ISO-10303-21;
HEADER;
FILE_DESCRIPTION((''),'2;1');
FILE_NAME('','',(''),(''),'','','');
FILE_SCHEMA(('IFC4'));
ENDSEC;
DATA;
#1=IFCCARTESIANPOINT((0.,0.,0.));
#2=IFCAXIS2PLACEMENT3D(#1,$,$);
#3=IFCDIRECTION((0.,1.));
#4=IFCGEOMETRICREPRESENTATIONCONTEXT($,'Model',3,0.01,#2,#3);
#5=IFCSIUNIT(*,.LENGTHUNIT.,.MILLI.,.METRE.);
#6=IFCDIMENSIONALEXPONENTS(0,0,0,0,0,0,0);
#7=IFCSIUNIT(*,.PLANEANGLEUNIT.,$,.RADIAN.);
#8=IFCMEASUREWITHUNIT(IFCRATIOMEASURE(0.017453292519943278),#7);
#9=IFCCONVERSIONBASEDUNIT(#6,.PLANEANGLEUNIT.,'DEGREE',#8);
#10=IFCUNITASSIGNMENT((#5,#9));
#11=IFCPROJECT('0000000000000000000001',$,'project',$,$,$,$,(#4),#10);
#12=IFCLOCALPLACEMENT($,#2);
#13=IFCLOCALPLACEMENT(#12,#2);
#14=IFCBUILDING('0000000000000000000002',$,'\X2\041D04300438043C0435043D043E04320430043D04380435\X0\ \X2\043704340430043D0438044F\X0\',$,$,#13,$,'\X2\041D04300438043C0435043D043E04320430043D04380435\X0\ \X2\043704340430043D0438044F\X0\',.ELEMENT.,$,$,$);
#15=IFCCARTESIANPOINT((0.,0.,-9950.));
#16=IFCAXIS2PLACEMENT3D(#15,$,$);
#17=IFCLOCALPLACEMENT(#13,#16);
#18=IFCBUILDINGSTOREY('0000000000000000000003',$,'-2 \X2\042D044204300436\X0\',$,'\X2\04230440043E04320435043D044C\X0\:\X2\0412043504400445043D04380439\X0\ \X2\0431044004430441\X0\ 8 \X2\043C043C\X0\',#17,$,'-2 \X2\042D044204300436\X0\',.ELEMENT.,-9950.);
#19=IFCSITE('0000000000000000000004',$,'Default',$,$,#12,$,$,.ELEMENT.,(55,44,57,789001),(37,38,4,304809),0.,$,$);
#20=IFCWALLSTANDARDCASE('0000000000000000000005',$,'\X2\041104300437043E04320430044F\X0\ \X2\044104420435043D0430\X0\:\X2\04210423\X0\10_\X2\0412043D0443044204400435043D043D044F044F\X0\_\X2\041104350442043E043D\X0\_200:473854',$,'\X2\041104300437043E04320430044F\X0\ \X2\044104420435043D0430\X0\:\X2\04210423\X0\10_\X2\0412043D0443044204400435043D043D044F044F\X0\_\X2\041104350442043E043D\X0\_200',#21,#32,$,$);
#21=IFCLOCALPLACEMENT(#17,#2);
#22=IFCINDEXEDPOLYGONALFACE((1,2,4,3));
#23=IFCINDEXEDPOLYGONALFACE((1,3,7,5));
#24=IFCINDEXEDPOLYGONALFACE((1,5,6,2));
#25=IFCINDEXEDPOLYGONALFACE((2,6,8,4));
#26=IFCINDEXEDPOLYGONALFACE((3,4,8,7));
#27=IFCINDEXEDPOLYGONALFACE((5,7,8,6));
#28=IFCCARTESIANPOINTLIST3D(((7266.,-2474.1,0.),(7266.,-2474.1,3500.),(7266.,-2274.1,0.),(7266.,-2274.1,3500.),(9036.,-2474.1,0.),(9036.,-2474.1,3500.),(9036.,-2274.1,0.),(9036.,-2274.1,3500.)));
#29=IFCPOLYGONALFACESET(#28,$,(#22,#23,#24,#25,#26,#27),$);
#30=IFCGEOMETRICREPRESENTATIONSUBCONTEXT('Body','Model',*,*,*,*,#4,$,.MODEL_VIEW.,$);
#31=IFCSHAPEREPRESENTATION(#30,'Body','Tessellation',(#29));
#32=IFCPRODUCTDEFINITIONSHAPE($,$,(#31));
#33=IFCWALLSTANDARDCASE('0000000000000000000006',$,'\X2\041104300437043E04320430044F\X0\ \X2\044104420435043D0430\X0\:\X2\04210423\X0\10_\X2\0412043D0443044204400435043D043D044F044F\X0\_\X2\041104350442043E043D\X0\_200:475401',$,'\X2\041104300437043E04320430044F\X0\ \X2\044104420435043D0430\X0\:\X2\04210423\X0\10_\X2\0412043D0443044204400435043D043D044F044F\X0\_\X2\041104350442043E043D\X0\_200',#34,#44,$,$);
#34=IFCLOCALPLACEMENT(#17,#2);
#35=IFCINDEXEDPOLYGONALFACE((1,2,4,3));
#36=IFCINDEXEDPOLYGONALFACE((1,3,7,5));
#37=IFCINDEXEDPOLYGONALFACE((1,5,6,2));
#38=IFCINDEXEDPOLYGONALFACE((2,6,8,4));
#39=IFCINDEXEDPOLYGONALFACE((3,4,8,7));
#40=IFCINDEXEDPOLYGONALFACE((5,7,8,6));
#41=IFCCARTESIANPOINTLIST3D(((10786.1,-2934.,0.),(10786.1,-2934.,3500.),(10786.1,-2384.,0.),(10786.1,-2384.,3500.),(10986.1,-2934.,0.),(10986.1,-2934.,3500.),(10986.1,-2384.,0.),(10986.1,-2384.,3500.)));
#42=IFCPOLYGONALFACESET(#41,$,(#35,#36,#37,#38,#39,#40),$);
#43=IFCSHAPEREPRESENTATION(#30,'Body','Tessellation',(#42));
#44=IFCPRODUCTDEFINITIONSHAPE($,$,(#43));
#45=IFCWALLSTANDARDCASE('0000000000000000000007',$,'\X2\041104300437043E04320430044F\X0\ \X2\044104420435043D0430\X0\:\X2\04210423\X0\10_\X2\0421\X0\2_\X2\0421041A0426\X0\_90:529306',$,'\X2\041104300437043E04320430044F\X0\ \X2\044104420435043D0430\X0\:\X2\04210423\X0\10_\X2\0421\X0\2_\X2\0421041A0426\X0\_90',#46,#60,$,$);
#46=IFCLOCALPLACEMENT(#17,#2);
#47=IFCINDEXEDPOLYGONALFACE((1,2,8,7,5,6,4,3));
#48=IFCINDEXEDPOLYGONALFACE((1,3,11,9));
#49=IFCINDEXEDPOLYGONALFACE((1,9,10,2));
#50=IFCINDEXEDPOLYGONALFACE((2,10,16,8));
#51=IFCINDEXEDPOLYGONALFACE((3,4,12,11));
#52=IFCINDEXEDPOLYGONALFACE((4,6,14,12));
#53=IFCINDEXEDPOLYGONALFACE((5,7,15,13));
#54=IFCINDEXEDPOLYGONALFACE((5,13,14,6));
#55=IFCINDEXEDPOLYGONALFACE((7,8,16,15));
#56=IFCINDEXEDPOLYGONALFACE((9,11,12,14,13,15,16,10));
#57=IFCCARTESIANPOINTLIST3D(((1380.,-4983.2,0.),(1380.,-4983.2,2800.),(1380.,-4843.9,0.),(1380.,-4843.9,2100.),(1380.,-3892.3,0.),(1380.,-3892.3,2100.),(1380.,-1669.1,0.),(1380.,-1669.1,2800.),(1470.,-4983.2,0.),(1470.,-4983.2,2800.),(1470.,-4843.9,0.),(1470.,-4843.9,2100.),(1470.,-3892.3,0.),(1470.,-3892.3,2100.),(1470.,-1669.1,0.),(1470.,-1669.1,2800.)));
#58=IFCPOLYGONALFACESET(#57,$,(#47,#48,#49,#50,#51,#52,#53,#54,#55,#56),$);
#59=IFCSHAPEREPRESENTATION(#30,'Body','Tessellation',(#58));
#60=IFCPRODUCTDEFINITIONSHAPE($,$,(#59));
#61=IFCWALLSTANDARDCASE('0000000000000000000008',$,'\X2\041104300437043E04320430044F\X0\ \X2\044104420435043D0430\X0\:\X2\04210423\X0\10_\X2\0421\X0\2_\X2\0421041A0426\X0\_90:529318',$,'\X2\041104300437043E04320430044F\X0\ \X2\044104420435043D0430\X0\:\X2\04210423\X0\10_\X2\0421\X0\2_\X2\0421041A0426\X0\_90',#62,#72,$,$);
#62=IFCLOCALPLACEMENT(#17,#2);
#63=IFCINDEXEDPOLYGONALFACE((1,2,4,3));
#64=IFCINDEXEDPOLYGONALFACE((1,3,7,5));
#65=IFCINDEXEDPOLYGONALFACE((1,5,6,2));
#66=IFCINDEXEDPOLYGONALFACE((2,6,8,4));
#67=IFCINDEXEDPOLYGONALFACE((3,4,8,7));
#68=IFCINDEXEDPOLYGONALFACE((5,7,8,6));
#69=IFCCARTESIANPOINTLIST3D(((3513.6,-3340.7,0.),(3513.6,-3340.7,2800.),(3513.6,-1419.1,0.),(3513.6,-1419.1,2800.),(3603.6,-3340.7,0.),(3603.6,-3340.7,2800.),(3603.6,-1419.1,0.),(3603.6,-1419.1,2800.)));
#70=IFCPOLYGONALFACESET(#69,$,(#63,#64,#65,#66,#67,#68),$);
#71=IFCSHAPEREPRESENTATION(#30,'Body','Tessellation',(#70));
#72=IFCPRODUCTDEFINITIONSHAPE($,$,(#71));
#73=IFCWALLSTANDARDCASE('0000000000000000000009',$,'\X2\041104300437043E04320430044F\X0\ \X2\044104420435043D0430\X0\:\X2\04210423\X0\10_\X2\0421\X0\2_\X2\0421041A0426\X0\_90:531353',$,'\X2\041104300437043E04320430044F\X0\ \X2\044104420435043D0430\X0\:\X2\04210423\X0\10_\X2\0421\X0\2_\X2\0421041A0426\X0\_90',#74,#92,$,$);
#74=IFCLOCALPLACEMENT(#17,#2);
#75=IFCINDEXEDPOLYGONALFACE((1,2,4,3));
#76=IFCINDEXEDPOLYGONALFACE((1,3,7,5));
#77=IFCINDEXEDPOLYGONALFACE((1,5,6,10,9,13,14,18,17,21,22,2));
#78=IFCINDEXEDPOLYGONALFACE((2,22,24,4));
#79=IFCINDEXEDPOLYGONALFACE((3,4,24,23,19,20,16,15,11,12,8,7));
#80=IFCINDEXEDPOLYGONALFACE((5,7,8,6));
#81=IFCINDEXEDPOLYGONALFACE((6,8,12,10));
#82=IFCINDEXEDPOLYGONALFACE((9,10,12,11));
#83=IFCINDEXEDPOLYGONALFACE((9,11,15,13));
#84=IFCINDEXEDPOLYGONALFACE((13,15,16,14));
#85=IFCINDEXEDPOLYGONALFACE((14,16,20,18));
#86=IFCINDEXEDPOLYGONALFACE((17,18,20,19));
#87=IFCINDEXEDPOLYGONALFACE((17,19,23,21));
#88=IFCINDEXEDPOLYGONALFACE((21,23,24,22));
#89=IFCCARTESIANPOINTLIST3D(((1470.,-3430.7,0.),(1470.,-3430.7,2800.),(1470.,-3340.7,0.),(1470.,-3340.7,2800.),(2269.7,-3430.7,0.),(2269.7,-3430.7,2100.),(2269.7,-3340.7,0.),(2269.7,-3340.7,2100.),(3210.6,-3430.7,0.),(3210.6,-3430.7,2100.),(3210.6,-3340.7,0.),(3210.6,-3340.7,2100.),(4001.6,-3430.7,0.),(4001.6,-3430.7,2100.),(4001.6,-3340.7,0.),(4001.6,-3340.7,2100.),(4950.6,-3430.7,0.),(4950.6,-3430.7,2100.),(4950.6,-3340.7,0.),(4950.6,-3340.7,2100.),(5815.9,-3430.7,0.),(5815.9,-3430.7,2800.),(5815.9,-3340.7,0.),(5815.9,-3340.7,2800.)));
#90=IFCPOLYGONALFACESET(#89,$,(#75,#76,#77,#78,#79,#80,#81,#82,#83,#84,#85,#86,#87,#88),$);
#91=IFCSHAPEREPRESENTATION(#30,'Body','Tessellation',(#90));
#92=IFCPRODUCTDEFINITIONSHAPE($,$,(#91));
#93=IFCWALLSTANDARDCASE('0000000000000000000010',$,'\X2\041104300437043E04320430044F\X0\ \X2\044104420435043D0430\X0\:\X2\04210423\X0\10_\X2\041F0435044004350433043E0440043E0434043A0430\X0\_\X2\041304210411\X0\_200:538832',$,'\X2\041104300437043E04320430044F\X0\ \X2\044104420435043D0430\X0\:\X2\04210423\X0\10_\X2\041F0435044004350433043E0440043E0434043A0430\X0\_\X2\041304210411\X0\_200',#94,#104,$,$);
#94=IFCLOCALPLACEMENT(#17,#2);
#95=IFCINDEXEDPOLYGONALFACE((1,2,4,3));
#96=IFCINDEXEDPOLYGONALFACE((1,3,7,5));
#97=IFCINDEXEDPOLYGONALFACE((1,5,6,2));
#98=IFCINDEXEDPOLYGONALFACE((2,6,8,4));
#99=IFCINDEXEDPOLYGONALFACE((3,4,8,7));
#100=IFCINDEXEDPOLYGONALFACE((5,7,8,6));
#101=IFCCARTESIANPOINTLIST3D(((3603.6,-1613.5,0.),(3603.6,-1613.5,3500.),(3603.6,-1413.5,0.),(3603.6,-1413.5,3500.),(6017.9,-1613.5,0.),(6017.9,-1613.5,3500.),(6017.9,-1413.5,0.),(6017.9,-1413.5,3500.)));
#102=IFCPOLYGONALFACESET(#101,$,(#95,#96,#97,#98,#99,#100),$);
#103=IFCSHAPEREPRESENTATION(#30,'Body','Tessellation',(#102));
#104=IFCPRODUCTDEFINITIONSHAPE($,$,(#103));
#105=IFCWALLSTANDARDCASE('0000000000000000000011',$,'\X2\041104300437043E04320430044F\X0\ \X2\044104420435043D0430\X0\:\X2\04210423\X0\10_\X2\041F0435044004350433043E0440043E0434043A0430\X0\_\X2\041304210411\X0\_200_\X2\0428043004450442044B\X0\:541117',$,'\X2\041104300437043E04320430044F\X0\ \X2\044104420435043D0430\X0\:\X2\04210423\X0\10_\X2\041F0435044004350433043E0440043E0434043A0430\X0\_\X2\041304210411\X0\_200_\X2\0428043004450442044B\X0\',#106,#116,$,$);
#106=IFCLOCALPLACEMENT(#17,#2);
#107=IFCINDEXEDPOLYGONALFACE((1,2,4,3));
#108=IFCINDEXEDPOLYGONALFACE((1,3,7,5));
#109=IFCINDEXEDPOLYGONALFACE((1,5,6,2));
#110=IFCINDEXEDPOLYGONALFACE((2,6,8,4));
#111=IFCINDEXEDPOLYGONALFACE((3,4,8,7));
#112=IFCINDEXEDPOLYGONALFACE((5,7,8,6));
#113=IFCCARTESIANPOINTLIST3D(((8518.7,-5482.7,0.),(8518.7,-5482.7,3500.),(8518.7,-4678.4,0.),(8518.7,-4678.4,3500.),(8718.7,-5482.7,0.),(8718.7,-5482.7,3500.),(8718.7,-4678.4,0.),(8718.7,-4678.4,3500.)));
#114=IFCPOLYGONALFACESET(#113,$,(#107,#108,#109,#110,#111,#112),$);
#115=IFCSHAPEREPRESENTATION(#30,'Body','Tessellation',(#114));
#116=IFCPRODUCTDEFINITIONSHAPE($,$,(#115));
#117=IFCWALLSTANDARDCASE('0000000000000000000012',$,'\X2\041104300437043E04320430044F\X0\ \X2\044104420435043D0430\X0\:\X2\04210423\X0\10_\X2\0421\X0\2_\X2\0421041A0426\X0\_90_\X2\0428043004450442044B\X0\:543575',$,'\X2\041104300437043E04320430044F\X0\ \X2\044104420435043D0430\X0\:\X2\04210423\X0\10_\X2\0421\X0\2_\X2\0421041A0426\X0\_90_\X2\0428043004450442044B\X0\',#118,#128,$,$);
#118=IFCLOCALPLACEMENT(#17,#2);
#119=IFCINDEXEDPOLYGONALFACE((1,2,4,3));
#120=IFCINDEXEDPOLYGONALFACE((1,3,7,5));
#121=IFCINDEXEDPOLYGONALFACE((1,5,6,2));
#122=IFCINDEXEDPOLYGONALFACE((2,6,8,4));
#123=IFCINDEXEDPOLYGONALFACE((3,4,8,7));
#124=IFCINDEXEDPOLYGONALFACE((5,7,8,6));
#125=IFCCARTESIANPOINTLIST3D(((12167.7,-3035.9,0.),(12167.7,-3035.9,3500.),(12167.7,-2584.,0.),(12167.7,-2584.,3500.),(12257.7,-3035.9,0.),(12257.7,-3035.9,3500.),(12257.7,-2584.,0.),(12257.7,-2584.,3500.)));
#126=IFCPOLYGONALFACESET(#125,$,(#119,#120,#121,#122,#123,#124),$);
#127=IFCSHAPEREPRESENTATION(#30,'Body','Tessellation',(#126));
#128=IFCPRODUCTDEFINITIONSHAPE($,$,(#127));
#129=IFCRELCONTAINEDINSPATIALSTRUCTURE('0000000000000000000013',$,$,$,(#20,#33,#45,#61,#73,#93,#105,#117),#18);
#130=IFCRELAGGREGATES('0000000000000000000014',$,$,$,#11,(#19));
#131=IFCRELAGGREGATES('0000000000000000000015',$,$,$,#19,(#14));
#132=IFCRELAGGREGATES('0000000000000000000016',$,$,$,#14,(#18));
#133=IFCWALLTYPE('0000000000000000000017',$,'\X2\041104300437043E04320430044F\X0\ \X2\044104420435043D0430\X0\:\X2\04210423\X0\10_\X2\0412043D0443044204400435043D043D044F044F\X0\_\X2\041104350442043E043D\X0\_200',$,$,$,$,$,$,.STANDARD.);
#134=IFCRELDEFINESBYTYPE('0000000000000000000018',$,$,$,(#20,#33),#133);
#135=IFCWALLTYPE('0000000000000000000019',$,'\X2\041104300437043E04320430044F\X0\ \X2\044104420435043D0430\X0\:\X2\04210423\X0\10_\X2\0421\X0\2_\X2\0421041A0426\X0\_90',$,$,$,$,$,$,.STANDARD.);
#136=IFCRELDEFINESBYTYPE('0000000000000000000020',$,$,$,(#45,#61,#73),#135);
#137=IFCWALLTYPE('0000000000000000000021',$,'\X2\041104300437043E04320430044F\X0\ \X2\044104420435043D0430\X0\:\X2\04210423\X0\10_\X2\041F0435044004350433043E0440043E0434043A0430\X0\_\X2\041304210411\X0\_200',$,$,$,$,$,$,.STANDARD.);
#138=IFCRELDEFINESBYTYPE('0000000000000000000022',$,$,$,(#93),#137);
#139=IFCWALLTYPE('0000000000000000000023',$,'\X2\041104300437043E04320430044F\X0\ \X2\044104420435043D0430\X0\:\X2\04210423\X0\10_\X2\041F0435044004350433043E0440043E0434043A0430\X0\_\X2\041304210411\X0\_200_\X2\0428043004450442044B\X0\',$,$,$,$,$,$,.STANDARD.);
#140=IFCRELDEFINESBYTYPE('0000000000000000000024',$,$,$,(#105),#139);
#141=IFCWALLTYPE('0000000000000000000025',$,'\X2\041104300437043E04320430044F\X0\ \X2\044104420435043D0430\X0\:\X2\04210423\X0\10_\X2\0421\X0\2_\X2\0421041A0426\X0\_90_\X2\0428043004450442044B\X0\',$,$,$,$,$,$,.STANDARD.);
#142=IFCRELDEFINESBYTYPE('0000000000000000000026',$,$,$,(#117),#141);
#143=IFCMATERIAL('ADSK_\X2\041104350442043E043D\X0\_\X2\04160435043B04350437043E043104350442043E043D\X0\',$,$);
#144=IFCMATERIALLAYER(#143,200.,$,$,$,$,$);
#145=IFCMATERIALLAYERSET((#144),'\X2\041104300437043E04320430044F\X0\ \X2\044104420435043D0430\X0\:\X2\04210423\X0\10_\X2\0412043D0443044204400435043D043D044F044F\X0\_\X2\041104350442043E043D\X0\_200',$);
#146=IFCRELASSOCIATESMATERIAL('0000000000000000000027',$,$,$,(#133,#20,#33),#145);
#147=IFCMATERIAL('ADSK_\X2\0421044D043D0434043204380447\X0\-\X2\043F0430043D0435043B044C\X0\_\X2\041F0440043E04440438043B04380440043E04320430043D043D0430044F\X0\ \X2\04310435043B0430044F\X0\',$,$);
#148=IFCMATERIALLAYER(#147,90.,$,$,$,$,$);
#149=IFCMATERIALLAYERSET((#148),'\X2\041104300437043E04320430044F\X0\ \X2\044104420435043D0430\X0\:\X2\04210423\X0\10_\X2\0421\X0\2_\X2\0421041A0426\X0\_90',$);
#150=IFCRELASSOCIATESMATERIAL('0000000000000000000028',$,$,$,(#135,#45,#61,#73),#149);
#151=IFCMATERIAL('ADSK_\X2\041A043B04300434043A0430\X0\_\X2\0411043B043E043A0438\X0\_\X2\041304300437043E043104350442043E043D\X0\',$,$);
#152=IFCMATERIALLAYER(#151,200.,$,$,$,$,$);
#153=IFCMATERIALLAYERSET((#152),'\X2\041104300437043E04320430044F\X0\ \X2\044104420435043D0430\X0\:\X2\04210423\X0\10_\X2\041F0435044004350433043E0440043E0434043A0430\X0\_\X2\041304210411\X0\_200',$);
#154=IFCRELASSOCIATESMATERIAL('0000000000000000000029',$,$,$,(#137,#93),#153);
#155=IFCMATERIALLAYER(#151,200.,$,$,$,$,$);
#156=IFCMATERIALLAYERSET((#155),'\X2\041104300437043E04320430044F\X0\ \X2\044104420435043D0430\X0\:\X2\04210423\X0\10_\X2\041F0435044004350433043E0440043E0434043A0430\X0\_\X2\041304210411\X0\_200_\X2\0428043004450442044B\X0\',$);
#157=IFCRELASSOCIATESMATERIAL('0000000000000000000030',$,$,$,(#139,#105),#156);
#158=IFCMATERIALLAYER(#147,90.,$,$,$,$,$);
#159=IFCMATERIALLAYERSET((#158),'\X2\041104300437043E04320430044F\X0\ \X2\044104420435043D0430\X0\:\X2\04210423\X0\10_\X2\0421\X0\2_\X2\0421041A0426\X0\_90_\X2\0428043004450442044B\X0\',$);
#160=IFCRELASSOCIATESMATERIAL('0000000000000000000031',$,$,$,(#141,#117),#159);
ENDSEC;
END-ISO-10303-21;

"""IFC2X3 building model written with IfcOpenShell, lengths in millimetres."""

from ifc_helpers import new_model, entity, si_unit, converted_unit, direction, frame, frame_2d, origin, place, context, subcontext, project, spatial, rectangle, extrude, material, layer, layer_set, layer_usage, type_object, element, save


model = new_model("IFC2X3")

# Units and contexts
model_context = context("Model", 3, precision=0.01, world=origin(), true_north=direction((0.0, 1.0)))
body_context = subcontext(model_context, "Body", "Model", "MODEL_VIEW")
ifc_project = project(units=[si_unit("LENGTHUNIT", "METRE", prefix="MILLI"), converted_unit("PLANEANGLEUNIT", "DEGREE", entity("IfcRatioMeasure", 0.017453292519943278), si_unit("PLANEANGLEUNIT", "RADIAN"), dimensions=[0, 0, 0, 0, 0, 0, 0])], contexts=[model_context])

# Site, building, storey
site_placement = place(None, origin())
site = spatial("IfcSite", under=ifc_project, at=site_placement, Name="Default", CompositionType="ELEMENT", RefLatitude=(55, 44, 57, 789001), RefLongitude=(37, 38, 4, 304809), RefElevation=0.0)
building_placement = place(site_placement, origin())
building = spatial("IfcBuilding", under=site, at=building_placement, Name="Наименование здания", LongName="Наименование здания", CompositionType="ELEMENT")
storey_placement = place(building_placement, frame((0.0, 0.0, -9950.0)))
storey = spatial("IfcBuildingStorey", under=building, at=storey_placement, Name="-2 Этаж", ObjectType="Уровень:Верхний брус 8 мм", LongName="-2 Этаж", CompositionType="ELEMENT", Elevation=-9950.0)

# Shared definitions
ifc_material_1 = material(Name="ADSK_Бетон_Железобетон")

# Walls
ifc_layer_1 = layer(ifc_material_1, 200.0)
ifc_layer_set_1 = layer_set([ifc_layer_1], Name="Базовая стена:СУ10_Внутренняя_Бетон_200")
ifc_layer_usage_1 = layer_usage(ifc_layer_set_1, "AXIS2", "NEGATIVE", 100.0)
wall_type_1 = type_object("IfcWallType", Name="Базовая стена:СУ10_Внутренняя_Бетон_200", PredefinedType="STANDARD", material=ifc_layer_set_1)
wall_1_placement = place(storey_placement, frame((9036.0, -2374.1, 0.0), z_axis=(0.0, 0.0, 1.0), x_axis=(-1.0, 0.0, 0.0)))
element("IfcWallStandardCase", 1, at=wall_1_placement, inside=storey, type_object=wall_type_1, material=ifc_layer_usage_1, Name="Базовая стена:СУ10_Внутренняя_Бетон_200:473854", ObjectType="Базовая стена:СУ10_Внутренняя_Бетон_200", context=body_context, shape_type="SweptSolid", body=[
    extrude(rectangle(XDim=1770.0, YDim=200.0, at=frame_2d((885.0, 0.0), x_axis=(-1.0, 0.0))), origin(), (0.0, 0.0, 1.0), 3500.0),
])
wall_2_placement = place(storey_placement, frame((10886.1, -2384.0, 0.0), z_axis=(0.0, 0.0, 1.0), x_axis=(0.0, -1.0, 0.0)))
element("IfcWallStandardCase", 2, at=wall_2_placement, inside=storey, type_object=wall_type_1, material=ifc_layer_usage_1, Name="Базовая стена:СУ10_Внутренняя_Бетон_200:475401", ObjectType="Базовая стена:СУ10_Внутренняя_Бетон_200", context=body_context, shape_type="SweptSolid", body=[
    extrude(rectangle(XDim=550.0, YDim=200.0, at=frame_2d((275.0, 0.0), x_axis=(-1.0, 0.0))), origin(), (0.0, 0.0, 1.0), 3500.0),
])

# Wall, opening
ifc_material_2 = material(Name="ADSK_Сэндвич-панель_Профилированная белая")
ifc_layer_2 = layer(ifc_material_2, 90.0)
ifc_layer_set_2 = layer_set([ifc_layer_2], Name="Базовая стена:СУ10_С2_СКЦ_90")
ifc_layer_usage_2 = layer_usage(ifc_layer_set_2, "AXIS2", "NEGATIVE", 45.0)
wall_type_2 = type_object("IfcWallType", Name="Базовая стена:СУ10_С2_СКЦ_90", PredefinedType="STANDARD", material=ifc_layer_set_2)
wall_3_placement = place(storey_placement, frame((1425.0, -1669.1, 0.0), z_axis=(0.0, 0.0, 1.0), x_axis=(0.0, -1.0, 0.0)))
wall_3 = element("IfcWallStandardCase", 3, at=wall_3_placement, inside=storey, type_object=wall_type_2, material=ifc_layer_usage_2, Name="Базовая стена:СУ10_С2_СКЦ_90:529306", ObjectType="Базовая стена:СУ10_С2_СКЦ_90", context=body_context, shape_type="SweptSolid", body=[
    extrude(rectangle(XDim=3314.1, YDim=90.0, at=frame_2d((1657.1, 0.0), x_axis=(-1.0, 0.0))), origin(), (0.0, 0.0, 1.0), 2800.0),
])
opening_1_placement = place(wall_3_placement, origin())
element("IfcOpeningElement", 4, at=opening_1_placement, cuts=wall_3, ObjectType="Opening", context=body_context, shape_type="SweptSolid", body=[
    extrude(rectangle(XDim=2100.0, YDim=951.5, at=frame_2d((0.0, 0.0), x_axis=(1.0, 0.0))), frame((2699.0, -45.0, 1050.0), z_axis=(0.0, 1.0, 0.0), x_axis=(0.0, 0.0, -1.0)), (0.0, 0.0, 1.0), 90.0),
])

# Wall
wall_4_placement = place(storey_placement, frame((3558.6, -1419.1, 0.0), z_axis=(0.0, 0.0, 1.0), x_axis=(0.0, -1.0, 0.0)))
element("IfcWallStandardCase", 5, at=wall_4_placement, inside=storey, type_object=wall_type_2, material=ifc_layer_usage_2, Name="Базовая стена:СУ10_С2_СКЦ_90:529318", ObjectType="Базовая стена:СУ10_С2_СКЦ_90", context=body_context, shape_type="SweptSolid", body=[
    extrude(rectangle(XDim=1921.6, YDim=90.0, at=frame_2d((960.8, 0.0), x_axis=(-1.0, 0.0))), origin(), (0.0, 0.0, 1.0), 2800.0),
])

# Wall, openings
wall_5_placement = place(storey_placement, frame((5815.9, -3385.7, 0.0), z_axis=(0.0, 0.0, 1.0), x_axis=(-1.0, 0.0, 0.0)))
wall_5 = element("IfcWallStandardCase", 6, at=wall_5_placement, inside=storey, type_object=wall_type_2, material=ifc_layer_usage_2, Name="Базовая стена:СУ10_С2_СКЦ_90:531353", ObjectType="Базовая стена:СУ10_С2_СКЦ_90", context=body_context, shape_type="SweptSolid", body=[
    extrude(rectangle(XDim=4345.8, YDim=90.0, at=frame_2d((2172.9, 0.0), x_axis=(1.0, 0.0))), origin(), (0.0, 0.0, 1.0), 2800.0),
])
opening_2_placement = place(wall_5_placement, origin())
element("IfcOpeningElement", 7, at=opening_2_placement, cuts=wall_5, ObjectType="Opening", context=body_context, shape_type="SweptSolid", body=[
    extrude(rectangle(XDim=2100.0, YDim=941.0, at=frame_2d((0.0, 0.0), x_axis=(1.0, 0.0))), frame((3075.7, -45.0, 1050.0), z_axis=(0.0, 1.0, 0.0), x_axis=(0.0, 0.0, -1.0)), (0.0, 0.0, 1.0), 90.0),
])
opening_3_placement = place(wall_5_placement, origin())
element("IfcOpeningElement", 8, at=opening_3_placement, cuts=wall_5, ObjectType="Opening", context=body_context, shape_type="SweptSolid", body=[
    extrude(rectangle(XDim=2100.0, YDim=949.1, at=frame_2d((0.0, 0.0), x_axis=(1.0, 0.0))), frame((1339.8, -45.0, 1050.0), z_axis=(0.0, 1.0, 0.0), x_axis=(0.0, 0.0, -1.0)), (0.0, 0.0, 1.0), 90.0),
])

# Walls
ifc_material_3 = material(Name="ADSK_Кладка_Блоки_Газобетон")
ifc_layer_3 = layer(ifc_material_3, 200.0)
ifc_layer_set_3 = layer_set([ifc_layer_3], Name="Базовая стена:СУ10_Перегородка_ГСБ_200")
ifc_layer_usage_3 = layer_usage(ifc_layer_set_3, "AXIS2", "NEGATIVE", 100.0)
wall_type_3 = type_object("IfcWallType", Name="Базовая стена:СУ10_Перегородка_ГСБ_200", PredefinedType="STANDARD", material=ifc_layer_set_3)
wall_6_placement = place(storey_placement, frame((6017.9, -1513.5, 0.0), z_axis=(0.0, 0.0, 1.0), x_axis=(-1.0, 0.0, 0.0)))
element("IfcWallStandardCase", 9, at=wall_6_placement, inside=storey, type_object=wall_type_3, material=ifc_layer_usage_3, Name="Базовая стена:СУ10_Перегородка_ГСБ_200:538832", ObjectType="Базовая стена:СУ10_Перегородка_ГСБ_200", context=body_context, shape_type="SweptSolid", body=[
    extrude(rectangle(XDim=2414.3, YDim=200.0, at=frame_2d((1207.2, 0.0), x_axis=(-1.0, 0.0))), origin(), (0.0, 0.0, 1.0), 3500.0),
])
ifc_layer_4 = layer(ifc_material_3, 200.0)
ifc_layer_set_4 = layer_set([ifc_layer_4], Name="Базовая стена:СУ10_Перегородка_ГСБ_200_Шахты")
ifc_layer_usage_4 = layer_usage(ifc_layer_set_4, "AXIS2", "NEGATIVE", 100.0)
wall_type_4 = type_object("IfcWallType", Name="Базовая стена:СУ10_Перегородка_ГСБ_200_Шахты", PredefinedType="STANDARD", material=ifc_layer_set_4)
wall_7_placement = place(storey_placement, frame((8618.7, -4678.4, 0.0), z_axis=(0.0, 0.0, 1.0), x_axis=(0.0, -1.0, 0.0)))
element("IfcWallStandardCase", 10, at=wall_7_placement, inside=storey, type_object=wall_type_4, material=ifc_layer_usage_4, Name="Базовая стена:СУ10_Перегородка_ГСБ_200_Шахты:541117", ObjectType="Базовая стена:СУ10_Перегородка_ГСБ_200_Шахты", context=body_context, shape_type="SweptSolid", body=[
    extrude(rectangle(XDim=804.3, YDim=200.0, at=frame_2d((402.2, 0.0), x_axis=(-1.0, 0.0))), origin(), (0.0, 0.0, 1.0), 3500.0),
])
ifc_layer_5 = layer(ifc_material_2, 90.0)
ifc_layer_set_5 = layer_set([ifc_layer_5], Name="Базовая стена:СУ10_С2_СКЦ_90_Шахты")
ifc_layer_usage_5 = layer_usage(ifc_layer_set_5, "AXIS2", "NEGATIVE", 45.0)
wall_type_5 = type_object("IfcWallType", Name="Базовая стена:СУ10_С2_СКЦ_90_Шахты", PredefinedType="STANDARD", material=ifc_layer_set_5)
wall_8_placement = place(storey_placement, frame((12212.7, -3035.9, 0.0), z_axis=(0.0, 0.0, 1.0), x_axis=(0.0, 1.0, 0.0)))
element("IfcWallStandardCase", 11, at=wall_8_placement, inside=storey, type_object=wall_type_5, material=ifc_layer_usage_5, Name="Базовая стена:СУ10_С2_СКЦ_90_Шахты:543575", ObjectType="Базовая стена:СУ10_С2_СКЦ_90_Шахты", context=body_context, shape_type="SweptSolid", body=[
    extrude(rectangle(XDim=451.9, YDim=90.0, at=frame_2d((225.9, 0.0), x_axis=(-1.0, 0.0))), origin(), (0.0, 0.0, 1.0), 3500.0),
])

save(model, "model.ifc")
